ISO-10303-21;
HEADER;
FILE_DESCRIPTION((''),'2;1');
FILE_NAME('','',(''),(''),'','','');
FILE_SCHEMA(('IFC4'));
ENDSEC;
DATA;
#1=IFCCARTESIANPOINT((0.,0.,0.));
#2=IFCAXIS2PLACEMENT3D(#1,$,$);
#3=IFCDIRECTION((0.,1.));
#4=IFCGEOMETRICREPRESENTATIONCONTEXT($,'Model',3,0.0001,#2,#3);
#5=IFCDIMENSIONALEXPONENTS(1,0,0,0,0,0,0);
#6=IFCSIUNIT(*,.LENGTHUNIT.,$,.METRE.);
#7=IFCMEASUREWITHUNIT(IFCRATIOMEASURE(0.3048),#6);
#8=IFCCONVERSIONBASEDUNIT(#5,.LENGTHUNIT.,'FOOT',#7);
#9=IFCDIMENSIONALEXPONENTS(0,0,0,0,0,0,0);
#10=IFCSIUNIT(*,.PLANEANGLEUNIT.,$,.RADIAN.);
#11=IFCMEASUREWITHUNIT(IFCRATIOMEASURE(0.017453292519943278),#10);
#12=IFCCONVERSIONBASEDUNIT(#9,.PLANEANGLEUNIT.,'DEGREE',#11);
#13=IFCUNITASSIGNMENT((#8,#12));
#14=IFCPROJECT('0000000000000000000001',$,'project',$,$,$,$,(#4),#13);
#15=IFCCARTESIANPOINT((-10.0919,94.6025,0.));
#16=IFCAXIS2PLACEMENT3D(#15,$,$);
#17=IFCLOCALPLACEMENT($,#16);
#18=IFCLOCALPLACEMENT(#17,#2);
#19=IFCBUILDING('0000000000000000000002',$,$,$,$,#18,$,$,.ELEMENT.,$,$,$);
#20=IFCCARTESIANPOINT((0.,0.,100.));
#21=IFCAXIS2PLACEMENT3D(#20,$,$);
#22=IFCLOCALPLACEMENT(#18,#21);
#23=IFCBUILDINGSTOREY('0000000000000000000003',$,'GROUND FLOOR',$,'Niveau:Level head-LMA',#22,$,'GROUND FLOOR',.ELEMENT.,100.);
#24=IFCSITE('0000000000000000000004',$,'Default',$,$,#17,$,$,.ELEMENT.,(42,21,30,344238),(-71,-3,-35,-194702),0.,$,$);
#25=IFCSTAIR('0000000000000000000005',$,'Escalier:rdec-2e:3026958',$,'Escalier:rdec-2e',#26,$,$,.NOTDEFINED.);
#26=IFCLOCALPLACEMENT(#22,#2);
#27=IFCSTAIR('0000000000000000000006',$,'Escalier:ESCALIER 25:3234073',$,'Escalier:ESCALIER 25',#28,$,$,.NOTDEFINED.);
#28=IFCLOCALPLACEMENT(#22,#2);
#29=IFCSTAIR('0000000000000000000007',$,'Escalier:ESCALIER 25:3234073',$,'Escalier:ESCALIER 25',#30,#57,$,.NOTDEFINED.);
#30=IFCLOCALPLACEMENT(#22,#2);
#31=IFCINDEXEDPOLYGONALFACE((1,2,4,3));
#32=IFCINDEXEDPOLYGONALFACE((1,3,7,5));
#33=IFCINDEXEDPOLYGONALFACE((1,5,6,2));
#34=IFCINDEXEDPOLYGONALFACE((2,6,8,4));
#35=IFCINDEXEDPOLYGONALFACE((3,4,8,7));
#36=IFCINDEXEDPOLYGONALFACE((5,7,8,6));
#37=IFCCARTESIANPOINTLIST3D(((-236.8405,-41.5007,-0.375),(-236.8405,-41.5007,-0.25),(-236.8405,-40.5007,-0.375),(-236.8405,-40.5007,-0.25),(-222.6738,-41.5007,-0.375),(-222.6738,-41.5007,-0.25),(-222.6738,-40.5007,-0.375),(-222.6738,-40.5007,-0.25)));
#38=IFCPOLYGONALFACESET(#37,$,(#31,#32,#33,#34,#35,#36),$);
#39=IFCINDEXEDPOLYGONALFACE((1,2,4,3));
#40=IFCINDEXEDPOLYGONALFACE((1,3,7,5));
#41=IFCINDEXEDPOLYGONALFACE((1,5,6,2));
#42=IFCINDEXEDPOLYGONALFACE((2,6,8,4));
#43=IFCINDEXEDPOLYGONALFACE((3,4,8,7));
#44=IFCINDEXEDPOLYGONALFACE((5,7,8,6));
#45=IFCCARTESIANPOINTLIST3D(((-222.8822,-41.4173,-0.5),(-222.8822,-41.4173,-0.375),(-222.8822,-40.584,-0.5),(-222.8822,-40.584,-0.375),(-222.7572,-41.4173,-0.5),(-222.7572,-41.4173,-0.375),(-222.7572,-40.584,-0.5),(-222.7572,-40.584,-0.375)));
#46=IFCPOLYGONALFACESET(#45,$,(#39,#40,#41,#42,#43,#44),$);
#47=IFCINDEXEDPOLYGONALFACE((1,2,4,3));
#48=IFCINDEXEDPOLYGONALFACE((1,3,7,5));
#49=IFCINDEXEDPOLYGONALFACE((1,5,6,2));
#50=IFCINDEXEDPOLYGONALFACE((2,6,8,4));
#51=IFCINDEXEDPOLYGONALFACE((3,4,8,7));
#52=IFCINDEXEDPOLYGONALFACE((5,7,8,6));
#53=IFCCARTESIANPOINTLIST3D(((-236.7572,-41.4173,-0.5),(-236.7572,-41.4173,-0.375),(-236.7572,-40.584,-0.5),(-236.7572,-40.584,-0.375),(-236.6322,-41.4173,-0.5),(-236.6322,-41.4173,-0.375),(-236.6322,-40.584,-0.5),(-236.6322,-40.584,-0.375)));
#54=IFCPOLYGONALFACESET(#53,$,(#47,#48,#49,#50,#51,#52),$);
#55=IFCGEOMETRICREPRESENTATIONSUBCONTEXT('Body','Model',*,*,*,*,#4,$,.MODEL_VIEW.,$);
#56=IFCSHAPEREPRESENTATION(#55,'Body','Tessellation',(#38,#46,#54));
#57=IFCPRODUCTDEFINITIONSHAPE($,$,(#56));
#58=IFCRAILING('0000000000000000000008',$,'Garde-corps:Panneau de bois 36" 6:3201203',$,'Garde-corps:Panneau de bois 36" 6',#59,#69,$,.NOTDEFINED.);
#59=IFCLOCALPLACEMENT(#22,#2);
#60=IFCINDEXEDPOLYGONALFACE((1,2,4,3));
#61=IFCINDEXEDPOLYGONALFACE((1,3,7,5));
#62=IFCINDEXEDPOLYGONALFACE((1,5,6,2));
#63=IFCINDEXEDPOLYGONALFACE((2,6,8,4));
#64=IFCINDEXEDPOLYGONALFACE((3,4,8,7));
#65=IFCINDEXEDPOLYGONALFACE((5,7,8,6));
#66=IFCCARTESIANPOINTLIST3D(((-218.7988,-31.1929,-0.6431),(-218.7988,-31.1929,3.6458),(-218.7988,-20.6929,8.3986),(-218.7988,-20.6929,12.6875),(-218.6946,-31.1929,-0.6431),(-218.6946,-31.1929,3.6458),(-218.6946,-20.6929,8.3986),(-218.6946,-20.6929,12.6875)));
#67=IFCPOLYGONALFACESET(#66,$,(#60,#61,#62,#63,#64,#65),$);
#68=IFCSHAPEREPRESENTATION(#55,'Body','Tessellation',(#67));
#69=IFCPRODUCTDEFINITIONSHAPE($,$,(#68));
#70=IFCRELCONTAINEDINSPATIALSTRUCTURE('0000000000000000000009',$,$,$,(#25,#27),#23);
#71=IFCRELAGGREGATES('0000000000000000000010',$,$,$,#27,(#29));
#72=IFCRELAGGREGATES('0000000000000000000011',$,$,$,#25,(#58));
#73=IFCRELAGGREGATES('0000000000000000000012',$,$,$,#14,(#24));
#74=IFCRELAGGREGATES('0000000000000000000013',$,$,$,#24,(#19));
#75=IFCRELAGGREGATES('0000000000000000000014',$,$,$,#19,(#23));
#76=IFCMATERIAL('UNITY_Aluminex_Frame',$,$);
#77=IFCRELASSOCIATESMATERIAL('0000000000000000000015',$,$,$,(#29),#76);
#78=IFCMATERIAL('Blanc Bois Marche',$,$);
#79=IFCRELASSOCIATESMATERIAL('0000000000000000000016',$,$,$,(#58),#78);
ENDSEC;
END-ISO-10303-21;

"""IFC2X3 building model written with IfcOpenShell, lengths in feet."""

from ifc_helpers import new_model, entity, si_unit, converted_unit, direction, frame, frame_2d, origin, place, context, subcontext, project, spatial, polyline, rectangle, outline, extrude, material, element, aggregate, save


model = new_model("IFC2X3")

# Units and contexts
model_context = context("Model", 3, precision=0.0001, world=origin(), true_north=direction((0.0, 1.0)))
body_context = subcontext(model_context, "Body", "Model", "MODEL_VIEW")
ifc_project = project(units=[converted_unit("LENGTHUNIT", "FOOT", entity("IfcRatioMeasure", 0.3048), si_unit("LENGTHUNIT", "METRE"), dimensions=[1, 0, 0, 0, 0, 0, 0]), converted_unit("PLANEANGLEUNIT", "DEGREE", entity("IfcRatioMeasure", 0.017453292519943278), si_unit("PLANEANGLEUNIT", "RADIAN"), dimensions=[0, 0, 0, 0, 0, 0, 0])], contexts=[model_context])

# Site, building, storey
site_placement = place(None, frame((-10.0919, 94.6025, 0.0)))
site = spatial("IfcSite", under=ifc_project, at=site_placement, Name="Default", CompositionType="ELEMENT", RefLatitude=(42, 21, 30, 344238), RefLongitude=(-71, -3, -35, -194702), RefElevation=0.0)
building_placement = place(site_placement, origin())
building = spatial("IfcBuilding", under=site, at=building_placement, CompositionType="ELEMENT")
storey_placement = place(building_placement, frame((0.0, 0.0, 100.0)))
storey = spatial("IfcBuildingStorey", under=building, at=storey_placement, Name="GROUND FLOOR", ObjectType="Niveau:Level head-LMA", LongName="GROUND FLOOR", CompositionType="ELEMENT", Elevation=100.0)

# Stairs
stair_1_placement = place(storey_placement, origin())
stair_1 = element("IfcStair", 1, at=stair_1_placement, inside=storey, Name="Escalier:rdec-2e:3026958", ObjectType="Escalier:rdec-2e", ShapeType="NOTDEFINED")
stair_2_placement = place(storey_placement, origin())
stair_2 = element("IfcStair", 2, at=stair_2_placement, inside=storey, Name="Escalier:ESCALIER 25:3234073", ObjectType="Escalier:ESCALIER 25", ShapeType="NOTDEFINED")
ifc_material_1 = material(Name="UNITY_Aluminex_Frame")
stair_3_placement = place(stair_2_placement, origin())
stair_3 = element("IfcStair", 3, at=stair_3_placement, material=ifc_material_1, Name="Escalier:ESCALIER 25:3234073", ObjectType="Escalier:ESCALIER 25", ShapeType="NOTDEFINED", context=body_context, shape_type="SweptSolid", body=[
    extrude(rectangle(XDim=1.0, YDim=14.1667, at=frame_2d((0.0, 0.0), x_axis=(1.0, 0.0))), frame((-229.7572, -41.0007, -0.375), z_axis=(0.0, 0.0, 1.0), x_axis=(0.0, -1.0, 0.0)), (0.0, 0.0, 1.0), 0.125),
    extrude(rectangle(XDim=0.8333, YDim=0.125, at=frame_2d((0.0, 0.0), x_axis=(1.0, 0.0))), frame((-222.8197, -41.0007, -0.5), z_axis=(0.0, 0.0, 1.0), x_axis=(0.0, -1.0, 0.0)), (0.0, 0.0, 1.0), 0.125),
    extrude(rectangle(XDim=0.8333, YDim=0.125, at=frame_2d((0.0, 0.0), x_axis=(1.0, 0.0))), frame((-236.6947, -41.0007, -0.5), z_axis=(0.0, 0.0, 1.0), x_axis=(0.0, -1.0, 0.0)), (0.0, 0.0, 1.0), 0.125),
])
aggregate(stair_2, [stair_3])

# Railing
ifc_material_2 = material(Name="Blanc Bois Marche")
railing_placement = place(stair_1_placement, frame((0.0, 0.0, 9.3333)))
railing = element("IfcRailing", 4, at=railing_placement, material=ifc_material_2, Name="Garde-corps:Panneau de bois 36\" 6:3201203", ObjectType="Garde-corps:Panneau de bois 36\" 6", PredefinedType="NOTDEFINED", context=body_context, shape_type="SweptSolid", body=[
    extrude(outline(polyline([(-8.3275, -1.625), (5.5289, -1.625), (8.3275, 1.625), (-5.5289, 1.625), (-8.3275, -1.625)])), frame((-218.7988, -25.9429, -3.3111), z_axis=(1.0, 0.0, 0.0), x_axis=(0.0, -0.757769, -0.652523)), (0.0, 0.0, 1.0), 0.1042),
])
aggregate(stair_1, [railing])

save(model, "model.ifc")
